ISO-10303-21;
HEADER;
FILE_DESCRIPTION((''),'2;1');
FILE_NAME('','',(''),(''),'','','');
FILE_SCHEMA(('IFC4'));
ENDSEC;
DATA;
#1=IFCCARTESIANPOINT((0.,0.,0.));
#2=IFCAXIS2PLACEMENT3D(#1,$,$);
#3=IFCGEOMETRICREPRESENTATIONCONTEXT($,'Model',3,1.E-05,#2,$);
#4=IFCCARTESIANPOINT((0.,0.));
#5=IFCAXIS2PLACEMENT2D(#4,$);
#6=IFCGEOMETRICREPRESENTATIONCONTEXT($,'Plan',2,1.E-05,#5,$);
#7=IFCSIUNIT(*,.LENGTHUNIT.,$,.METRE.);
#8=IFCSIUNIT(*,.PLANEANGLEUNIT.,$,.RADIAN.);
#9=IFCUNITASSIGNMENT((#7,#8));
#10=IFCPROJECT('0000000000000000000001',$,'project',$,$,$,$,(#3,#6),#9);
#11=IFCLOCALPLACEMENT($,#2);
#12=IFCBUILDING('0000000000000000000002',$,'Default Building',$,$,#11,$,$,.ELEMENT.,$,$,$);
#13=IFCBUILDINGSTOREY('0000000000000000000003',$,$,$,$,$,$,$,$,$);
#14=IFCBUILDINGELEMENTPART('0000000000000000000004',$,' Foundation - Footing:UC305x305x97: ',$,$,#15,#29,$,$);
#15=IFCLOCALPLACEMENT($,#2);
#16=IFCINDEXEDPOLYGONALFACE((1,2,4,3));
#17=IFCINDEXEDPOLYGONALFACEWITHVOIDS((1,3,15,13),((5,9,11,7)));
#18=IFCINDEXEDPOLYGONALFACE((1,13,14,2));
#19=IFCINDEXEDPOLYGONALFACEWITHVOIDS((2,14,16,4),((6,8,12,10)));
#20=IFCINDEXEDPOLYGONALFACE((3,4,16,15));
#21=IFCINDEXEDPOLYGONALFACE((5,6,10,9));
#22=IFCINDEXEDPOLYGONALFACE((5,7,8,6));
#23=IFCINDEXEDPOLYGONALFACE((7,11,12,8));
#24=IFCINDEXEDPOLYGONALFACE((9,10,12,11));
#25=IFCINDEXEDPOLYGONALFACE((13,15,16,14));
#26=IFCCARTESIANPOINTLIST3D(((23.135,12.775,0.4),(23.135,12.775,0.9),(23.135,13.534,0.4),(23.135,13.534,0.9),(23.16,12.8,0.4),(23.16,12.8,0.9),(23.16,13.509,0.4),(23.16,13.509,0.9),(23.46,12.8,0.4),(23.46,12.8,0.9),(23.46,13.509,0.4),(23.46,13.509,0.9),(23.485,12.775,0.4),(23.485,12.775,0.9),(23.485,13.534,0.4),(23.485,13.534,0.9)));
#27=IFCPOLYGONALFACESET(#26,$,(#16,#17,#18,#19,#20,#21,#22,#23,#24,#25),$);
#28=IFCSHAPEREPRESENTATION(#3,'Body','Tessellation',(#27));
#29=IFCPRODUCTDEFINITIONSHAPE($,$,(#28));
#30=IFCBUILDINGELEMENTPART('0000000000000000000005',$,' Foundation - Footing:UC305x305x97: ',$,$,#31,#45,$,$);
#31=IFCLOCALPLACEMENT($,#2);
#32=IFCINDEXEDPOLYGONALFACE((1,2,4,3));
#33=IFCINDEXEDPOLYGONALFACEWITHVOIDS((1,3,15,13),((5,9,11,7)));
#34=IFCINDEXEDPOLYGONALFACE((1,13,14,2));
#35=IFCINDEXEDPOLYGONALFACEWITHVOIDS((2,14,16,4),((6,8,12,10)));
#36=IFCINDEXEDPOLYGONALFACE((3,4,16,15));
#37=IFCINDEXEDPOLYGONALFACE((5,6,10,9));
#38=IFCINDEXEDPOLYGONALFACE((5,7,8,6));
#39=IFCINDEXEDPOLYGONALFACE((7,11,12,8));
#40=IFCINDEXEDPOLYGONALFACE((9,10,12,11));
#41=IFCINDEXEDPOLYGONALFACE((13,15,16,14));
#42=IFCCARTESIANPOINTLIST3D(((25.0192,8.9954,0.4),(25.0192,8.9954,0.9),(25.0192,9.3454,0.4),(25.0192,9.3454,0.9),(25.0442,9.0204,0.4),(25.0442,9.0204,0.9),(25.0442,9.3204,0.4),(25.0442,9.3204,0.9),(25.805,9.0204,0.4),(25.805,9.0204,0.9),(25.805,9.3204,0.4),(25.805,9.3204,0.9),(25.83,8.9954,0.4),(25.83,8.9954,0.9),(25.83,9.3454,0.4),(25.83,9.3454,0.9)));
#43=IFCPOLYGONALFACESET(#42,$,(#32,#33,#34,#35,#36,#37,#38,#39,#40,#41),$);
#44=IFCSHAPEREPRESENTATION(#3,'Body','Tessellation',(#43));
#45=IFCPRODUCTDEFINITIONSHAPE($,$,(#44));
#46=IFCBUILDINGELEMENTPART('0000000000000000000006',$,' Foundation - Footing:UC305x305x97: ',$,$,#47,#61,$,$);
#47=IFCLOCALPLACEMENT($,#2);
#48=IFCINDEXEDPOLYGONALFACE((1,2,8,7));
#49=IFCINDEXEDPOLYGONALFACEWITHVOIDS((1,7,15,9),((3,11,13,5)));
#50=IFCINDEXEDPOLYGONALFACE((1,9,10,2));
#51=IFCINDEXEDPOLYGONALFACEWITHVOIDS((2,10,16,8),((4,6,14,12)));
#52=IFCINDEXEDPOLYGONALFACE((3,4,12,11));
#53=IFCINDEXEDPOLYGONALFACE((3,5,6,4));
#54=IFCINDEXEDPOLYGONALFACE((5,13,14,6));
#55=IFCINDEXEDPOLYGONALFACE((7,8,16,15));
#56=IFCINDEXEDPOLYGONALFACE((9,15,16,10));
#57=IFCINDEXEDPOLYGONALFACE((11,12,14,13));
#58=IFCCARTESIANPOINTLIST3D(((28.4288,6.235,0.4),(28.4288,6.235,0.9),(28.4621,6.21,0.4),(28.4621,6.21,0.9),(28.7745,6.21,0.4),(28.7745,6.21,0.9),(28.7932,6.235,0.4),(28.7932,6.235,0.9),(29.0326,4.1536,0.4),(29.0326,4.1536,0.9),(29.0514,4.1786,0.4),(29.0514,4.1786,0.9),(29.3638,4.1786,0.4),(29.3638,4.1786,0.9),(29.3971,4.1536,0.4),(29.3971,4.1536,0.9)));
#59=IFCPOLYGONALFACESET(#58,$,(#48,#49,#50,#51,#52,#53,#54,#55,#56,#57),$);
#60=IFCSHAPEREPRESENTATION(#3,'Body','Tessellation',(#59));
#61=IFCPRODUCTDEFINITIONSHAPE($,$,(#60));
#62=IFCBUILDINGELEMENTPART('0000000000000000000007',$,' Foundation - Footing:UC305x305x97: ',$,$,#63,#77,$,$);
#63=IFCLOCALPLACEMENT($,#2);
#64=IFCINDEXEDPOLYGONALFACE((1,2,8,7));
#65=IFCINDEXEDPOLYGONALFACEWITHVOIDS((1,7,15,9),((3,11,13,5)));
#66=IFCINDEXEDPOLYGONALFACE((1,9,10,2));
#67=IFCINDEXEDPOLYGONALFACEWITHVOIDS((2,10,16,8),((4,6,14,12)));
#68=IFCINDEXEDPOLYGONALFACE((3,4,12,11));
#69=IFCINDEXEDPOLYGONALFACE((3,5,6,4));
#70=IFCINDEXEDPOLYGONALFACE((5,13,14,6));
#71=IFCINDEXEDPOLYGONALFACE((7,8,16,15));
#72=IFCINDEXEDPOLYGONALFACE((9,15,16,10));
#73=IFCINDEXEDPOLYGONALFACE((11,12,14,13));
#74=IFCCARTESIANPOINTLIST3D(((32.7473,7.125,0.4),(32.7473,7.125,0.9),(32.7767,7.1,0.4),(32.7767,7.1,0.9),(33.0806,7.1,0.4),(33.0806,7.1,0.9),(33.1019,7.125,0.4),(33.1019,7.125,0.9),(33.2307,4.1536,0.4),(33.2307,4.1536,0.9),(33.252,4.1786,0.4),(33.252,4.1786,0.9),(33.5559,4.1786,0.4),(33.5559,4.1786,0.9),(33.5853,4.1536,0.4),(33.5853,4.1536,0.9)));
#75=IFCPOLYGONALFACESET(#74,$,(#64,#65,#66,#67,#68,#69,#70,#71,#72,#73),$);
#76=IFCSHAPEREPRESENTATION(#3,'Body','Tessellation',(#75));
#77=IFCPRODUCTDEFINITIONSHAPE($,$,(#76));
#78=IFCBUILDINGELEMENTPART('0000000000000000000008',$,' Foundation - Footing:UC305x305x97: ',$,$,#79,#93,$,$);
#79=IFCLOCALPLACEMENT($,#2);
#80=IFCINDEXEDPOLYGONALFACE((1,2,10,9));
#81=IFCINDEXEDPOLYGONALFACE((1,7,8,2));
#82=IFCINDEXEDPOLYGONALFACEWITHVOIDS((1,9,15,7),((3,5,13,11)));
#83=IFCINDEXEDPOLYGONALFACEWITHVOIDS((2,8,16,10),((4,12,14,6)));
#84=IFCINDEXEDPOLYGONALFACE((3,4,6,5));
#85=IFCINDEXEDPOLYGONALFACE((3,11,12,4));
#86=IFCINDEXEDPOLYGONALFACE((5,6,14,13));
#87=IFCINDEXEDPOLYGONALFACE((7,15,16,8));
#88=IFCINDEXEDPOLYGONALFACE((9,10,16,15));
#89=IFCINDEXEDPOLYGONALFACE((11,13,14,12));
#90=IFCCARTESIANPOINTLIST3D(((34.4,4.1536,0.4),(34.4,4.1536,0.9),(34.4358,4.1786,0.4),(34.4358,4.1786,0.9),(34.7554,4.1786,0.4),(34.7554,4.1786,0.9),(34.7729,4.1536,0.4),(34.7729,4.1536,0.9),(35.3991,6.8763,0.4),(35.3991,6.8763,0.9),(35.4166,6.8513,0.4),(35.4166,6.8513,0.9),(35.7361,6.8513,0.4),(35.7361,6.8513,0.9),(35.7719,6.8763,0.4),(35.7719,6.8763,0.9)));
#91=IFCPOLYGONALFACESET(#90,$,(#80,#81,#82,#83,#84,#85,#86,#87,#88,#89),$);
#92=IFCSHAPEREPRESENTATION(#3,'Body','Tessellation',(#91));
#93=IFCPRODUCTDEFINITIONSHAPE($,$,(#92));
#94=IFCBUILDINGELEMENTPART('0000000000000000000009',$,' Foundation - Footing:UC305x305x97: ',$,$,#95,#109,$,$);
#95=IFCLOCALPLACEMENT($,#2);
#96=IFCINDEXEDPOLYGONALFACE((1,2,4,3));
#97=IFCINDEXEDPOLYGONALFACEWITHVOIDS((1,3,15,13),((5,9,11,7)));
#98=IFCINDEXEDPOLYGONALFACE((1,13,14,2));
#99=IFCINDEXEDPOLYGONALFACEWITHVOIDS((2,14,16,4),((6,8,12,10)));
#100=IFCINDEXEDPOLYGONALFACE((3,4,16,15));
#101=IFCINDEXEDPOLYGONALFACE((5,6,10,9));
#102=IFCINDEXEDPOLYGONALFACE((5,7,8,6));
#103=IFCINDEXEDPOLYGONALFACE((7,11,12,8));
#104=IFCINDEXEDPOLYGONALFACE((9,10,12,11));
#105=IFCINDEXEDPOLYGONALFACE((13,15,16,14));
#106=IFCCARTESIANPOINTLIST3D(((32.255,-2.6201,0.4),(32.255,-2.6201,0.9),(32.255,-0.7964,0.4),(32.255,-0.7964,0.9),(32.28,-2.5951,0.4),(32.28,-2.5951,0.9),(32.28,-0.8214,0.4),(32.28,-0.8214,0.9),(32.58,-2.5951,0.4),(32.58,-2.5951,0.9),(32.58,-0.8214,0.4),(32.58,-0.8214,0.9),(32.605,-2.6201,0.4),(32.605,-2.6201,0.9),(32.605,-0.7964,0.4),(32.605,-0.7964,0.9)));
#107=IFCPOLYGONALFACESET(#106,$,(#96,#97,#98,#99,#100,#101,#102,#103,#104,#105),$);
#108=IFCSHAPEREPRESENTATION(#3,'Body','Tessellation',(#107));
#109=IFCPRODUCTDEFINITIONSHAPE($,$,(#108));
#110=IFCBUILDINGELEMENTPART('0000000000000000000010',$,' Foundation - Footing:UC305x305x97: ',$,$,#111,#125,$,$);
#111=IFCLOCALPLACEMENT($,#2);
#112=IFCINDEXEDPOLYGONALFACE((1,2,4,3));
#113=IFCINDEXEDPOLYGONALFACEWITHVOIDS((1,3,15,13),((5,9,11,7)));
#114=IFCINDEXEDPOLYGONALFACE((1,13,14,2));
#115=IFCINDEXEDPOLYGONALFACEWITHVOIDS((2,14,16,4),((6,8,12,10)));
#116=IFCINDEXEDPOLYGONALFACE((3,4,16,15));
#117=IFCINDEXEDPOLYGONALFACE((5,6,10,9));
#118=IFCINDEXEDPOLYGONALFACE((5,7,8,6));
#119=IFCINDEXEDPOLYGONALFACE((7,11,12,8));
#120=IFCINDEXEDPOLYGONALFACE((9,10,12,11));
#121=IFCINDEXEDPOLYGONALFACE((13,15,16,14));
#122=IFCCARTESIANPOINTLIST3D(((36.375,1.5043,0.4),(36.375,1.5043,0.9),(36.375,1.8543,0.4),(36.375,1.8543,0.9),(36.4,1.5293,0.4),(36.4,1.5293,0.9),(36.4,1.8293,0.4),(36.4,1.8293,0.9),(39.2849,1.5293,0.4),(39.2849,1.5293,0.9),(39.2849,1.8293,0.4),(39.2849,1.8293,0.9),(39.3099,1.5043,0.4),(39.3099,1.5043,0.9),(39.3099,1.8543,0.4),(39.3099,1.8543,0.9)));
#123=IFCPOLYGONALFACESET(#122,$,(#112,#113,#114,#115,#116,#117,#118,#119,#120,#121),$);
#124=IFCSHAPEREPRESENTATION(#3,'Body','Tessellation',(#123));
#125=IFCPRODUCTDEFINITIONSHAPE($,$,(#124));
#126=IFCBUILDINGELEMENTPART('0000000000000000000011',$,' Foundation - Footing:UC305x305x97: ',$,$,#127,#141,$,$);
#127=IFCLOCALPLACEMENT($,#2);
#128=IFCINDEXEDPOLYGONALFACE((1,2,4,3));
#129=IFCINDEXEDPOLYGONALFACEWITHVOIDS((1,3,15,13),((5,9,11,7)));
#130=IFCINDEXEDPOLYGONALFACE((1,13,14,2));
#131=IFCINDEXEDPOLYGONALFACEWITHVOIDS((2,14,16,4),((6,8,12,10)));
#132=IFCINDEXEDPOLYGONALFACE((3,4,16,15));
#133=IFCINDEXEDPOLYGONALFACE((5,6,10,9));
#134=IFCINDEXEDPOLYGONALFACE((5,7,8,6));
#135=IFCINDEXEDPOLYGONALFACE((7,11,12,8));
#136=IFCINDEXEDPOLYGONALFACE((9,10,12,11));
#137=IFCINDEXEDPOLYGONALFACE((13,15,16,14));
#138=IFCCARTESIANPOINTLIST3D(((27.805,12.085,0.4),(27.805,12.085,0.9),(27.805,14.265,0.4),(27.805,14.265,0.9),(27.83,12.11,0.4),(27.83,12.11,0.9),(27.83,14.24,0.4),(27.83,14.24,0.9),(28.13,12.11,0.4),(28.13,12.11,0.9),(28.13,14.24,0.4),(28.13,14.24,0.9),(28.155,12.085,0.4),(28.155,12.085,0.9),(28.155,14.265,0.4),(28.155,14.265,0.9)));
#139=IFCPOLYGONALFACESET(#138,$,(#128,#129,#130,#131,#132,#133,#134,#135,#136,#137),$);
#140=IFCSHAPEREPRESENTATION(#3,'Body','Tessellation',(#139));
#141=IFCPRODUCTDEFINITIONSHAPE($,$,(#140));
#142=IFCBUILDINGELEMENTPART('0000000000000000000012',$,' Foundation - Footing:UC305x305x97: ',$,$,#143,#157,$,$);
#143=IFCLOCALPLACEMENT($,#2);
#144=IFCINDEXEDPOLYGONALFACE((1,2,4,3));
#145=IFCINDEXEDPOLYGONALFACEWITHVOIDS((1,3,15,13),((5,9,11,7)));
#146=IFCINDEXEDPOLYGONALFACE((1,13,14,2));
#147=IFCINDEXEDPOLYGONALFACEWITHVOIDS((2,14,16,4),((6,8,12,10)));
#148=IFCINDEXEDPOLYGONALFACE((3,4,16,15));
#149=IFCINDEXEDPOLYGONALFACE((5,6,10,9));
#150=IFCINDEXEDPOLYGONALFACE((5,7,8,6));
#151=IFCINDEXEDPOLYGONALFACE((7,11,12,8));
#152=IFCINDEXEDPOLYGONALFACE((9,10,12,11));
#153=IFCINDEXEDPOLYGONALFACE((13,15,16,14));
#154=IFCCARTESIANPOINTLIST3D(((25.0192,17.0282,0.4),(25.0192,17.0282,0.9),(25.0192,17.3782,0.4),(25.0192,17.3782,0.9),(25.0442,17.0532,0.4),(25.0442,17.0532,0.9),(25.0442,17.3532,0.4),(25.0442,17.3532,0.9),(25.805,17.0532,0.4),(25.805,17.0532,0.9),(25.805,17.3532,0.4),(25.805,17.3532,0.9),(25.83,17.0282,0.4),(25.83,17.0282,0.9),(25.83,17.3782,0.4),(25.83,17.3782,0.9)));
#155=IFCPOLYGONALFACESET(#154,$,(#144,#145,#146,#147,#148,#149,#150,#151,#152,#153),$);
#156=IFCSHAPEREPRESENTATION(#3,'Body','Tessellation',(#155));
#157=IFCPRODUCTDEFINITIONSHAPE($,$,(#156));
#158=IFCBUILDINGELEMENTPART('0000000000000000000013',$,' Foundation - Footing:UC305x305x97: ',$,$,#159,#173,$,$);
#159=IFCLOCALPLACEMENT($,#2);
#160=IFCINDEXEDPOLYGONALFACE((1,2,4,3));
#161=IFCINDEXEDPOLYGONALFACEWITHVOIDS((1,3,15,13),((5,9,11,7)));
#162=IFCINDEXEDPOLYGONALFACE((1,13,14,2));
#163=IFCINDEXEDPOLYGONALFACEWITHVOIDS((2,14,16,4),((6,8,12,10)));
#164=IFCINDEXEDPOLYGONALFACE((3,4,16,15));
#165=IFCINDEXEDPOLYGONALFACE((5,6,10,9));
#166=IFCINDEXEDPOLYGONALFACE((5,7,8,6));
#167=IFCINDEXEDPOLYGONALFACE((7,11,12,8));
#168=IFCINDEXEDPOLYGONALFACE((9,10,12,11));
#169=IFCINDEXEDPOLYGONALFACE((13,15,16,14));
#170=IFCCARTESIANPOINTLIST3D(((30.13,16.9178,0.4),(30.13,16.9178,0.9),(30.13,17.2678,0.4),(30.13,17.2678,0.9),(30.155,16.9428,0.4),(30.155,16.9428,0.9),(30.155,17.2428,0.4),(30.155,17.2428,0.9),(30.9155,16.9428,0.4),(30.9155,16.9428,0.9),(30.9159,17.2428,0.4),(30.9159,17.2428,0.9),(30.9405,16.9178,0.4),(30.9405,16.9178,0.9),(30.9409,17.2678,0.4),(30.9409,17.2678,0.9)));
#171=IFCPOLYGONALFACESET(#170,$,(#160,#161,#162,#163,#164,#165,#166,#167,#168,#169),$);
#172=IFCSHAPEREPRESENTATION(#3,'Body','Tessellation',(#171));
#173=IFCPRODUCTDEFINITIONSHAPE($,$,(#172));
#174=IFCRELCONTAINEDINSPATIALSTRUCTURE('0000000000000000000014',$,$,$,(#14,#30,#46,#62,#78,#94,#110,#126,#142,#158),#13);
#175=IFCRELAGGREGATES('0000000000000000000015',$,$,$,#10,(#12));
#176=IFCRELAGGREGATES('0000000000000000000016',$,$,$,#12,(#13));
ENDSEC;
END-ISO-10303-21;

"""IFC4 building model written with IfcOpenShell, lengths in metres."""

from ifc_helpers import new_model, si_unit, origin, origin_2d, place, context, project, spatial, polyline, outline, extrude, element, save


model = new_model("IFC4")

# Units and contexts
model_context = context("Model", 3, precision=1e-05, world=origin())
plan_context = context("Plan", 2, precision=1e-05, world=origin_2d())
ifc_project = project(units=[si_unit("LENGTHUNIT", "METRE"), si_unit("PLANEANGLEUNIT", "RADIAN")], contexts=[model_context, plan_context])

# Building, storey
building_placement = place(None, origin())
building = spatial("IfcBuilding", under=ifc_project, at=building_placement, Name="Default Building", CompositionType="ELEMENT")
storey = spatial("IfcBuildingStorey", under=building)

# Building element parts, openings
building_element_part_1 = element("IfcBuildingElementPart", 1, inside=storey, Name=" Foundation - Footing:UC305x305x97: ", context=model_context, shape_type="SweptSolid", body=[
    extrude(outline(polyline([(23.135, 12.775, 0.4), (23.485, 12.775, 0.4), (23.485, 13.534, 0.4), (23.135, 13.534, 0.4), (23.135, 12.775, 0.4)])), None, (0.0, 0.0, 1.0), 0.5),
])
element("IfcOpeningElement", 2, inside=storey, cuts=building_element_part_1, context=model_context, shape_type="SweptSolid", body=[
    extrude(outline(polyline([(23.16, 12.8, 0.4), (23.46, 12.8, 0.4), (23.46, 13.509, 0.4), (23.16, 13.509, 0.4), (23.16, 12.8, 0.4)])), None, (0.0, 0.0, 1.0), 0.5),
])
building_element_part_2 = element("IfcBuildingElementPart", 3, inside=storey, Name=" Foundation - Footing:UC305x305x97: ", context=model_context, shape_type="SweptSolid", body=[
    extrude(outline(polyline([(25.0192, 8.9954, 0.4), (25.83, 8.9954, 0.4), (25.83, 9.3454, 0.4), (25.0192, 9.3454, 0.4), (25.0192, 8.9954, 0.4)])), None, (0.0, 0.0, 1.0), 0.5),
])
element("IfcOpeningElement", 4, inside=storey, cuts=building_element_part_2, context=model_context, shape_type="SweptSolid", body=[
    extrude(outline(polyline([(25.0442, 9.0204, 0.4), (25.805, 9.0204, 0.4), (25.805, 9.3204, 0.4), (25.0442, 9.3204, 0.4), (25.0442, 9.0204, 0.4)])), None, (0.0, 0.0, 1.0), 0.5),
])
building_element_part_3 = element("IfcBuildingElementPart", 5, inside=storey, Name=" Foundation - Footing:UC305x305x97: ", context=model_context, shape_type="SweptSolid", body=[
    extrude(outline(polyline([(29.0326, 4.1536, 0.4), (29.3971, 4.1536, 0.4), (28.7932, 6.235, 0.4), (28.4288, 6.235, 0.4), (29.0326, 4.1536, 0.4)])), None, (0.0, 0.0, 1.0), 0.5),
])
element("IfcOpeningElement", 6, inside=storey, cuts=building_element_part_3, context=model_context, shape_type="SweptSolid", body=[
    extrude(outline(polyline([(29.0514, 4.1786, 0.4), (29.3638, 4.1786, 0.4), (28.7745, 6.21, 0.4), (28.4621, 6.21, 0.4), (29.0514, 4.1786, 0.4)])), None, (0.0, 0.0, 1.0), 0.5),
])
building_element_part_4 = element("IfcBuildingElementPart", 7, inside=storey, Name=" Foundation - Footing:UC305x305x97: ", context=model_context, shape_type="SweptSolid", body=[
    extrude(outline(polyline([(33.2307, 4.1536, 0.4), (33.5853, 4.1536, 0.4), (33.1019, 7.125, 0.4), (32.7473, 7.125, 0.4), (33.2307, 4.1536, 0.4)])), None, (0.0, 0.0, 1.0), 0.5),
])
element("IfcOpeningElement", 8, inside=storey, cuts=building_element_part_4, context=model_context, shape_type="SweptSolid", body=[
    extrude(outline(polyline([(33.252, 4.1786, 0.4), (33.5559, 4.1786, 0.4), (33.0806, 7.1, 0.4), (32.7767, 7.1, 0.4), (33.252, 4.1786, 0.4)])), None, (0.0, 0.0, 1.0), 0.5),
])
building_element_part_5 = element("IfcBuildingElementPart", 9, inside=storey, Name=" Foundation - Footing:UC305x305x97: ", context=model_context, shape_type="SweptSolid", body=[
    extrude(outline(polyline([(34.4, 4.1536, 0.4), (34.7729, 4.1536, 0.4), (35.7719, 6.8763, 0.4), (35.3991, 6.8763, 0.4), (34.4, 4.1536, 0.4)])), None, (0.0, 0.0, 1.0), 0.5),
])
element("IfcOpeningElement", 10, inside=storey, cuts=building_element_part_5, context=model_context, shape_type="SweptSolid", body=[
    extrude(outline(polyline([(34.4358, 4.1786, 0.4), (34.7554, 4.1786, 0.4), (35.7361, 6.8513, 0.4), (35.4166, 6.8513, 0.4), (34.4358, 4.1786, 0.4)])), None, (0.0, 0.0, 1.0), 0.5),
])
building_element_part_6 = element("IfcBuildingElementPart", 11, inside=storey, Name=" Foundation - Footing:UC305x305x97: ", context=model_context, shape_type="SweptSolid", body=[
    extrude(outline(polyline([(32.255, -2.6201, 0.4), (32.605, -2.6201, 0.4), (32.605, -0.7964, 0.4), (32.255, -0.7964, 0.4), (32.255, -2.6201, 0.4)])), None, (0.0, 0.0, 1.0), 0.5),
])
element("IfcOpeningElement", 12, inside=storey, cuts=building_element_part_6, context=model_context, shape_type="SweptSolid", body=[
    extrude(outline(polyline([(32.28, -2.5951, 0.4), (32.58, -2.5951, 0.4), (32.58, -0.8214, 0.4), (32.28, -0.8214, 0.4), (32.28, -2.5951, 0.4)])), None, (0.0, 0.0, 1.0), 0.5),
])
building_element_part_7 = element("IfcBuildingElementPart", 13, inside=storey, Name=" Foundation - Footing:UC305x305x97: ", context=model_context, shape_type="SweptSolid", body=[
    extrude(outline(polyline([(36.375, 1.5043, 0.4), (36.375, 1.8543, 0.4), (39.3099, 1.8543, 0.4), (39.3099, 1.5043, 0.4), (36.375, 1.5043, 0.4)])), None, (0.0, 0.0, 1.0), 0.5),
])
element("IfcOpeningElement", 14, inside=storey, cuts=building_element_part_7, context=model_context, shape_type="SweptSolid", body=[
    extrude(outline(polyline([(36.4, 1.5293, 0.4), (36.4, 1.8293, 0.4), (39.2849, 1.8293, 0.4), (39.2849, 1.5293, 0.4), (36.4, 1.5293, 0.4)])), None, (0.0, 0.0, 1.0), 0.5),
])
building_element_part_8 = element("IfcBuildingElementPart", 15, inside=storey, Name=" Foundation - Footing:UC305x305x97: ", context=model_context, shape_type="SweptSolid", body=[
    extrude(outline(polyline([(27.805, 12.085, 0.4), (28.155, 12.085, 0.4), (28.155, 14.265, 0.4), (27.805, 14.265, 0.4), (27.805, 12.085, 0.4)])), None, (0.0, 0.0, 1.0), 0.5),
])
element("IfcOpeningElement", 16, inside=storey, cuts=building_element_part_8, context=model_context, shape_type="SweptSolid", body=[
    extrude(outline(polyline([(27.83, 12.11, 0.4), (28.13, 12.11, 0.4), (28.13, 14.24, 0.4), (27.83, 14.24, 0.4), (27.83, 12.11, 0.4)])), None, (0.0, 0.0, 1.0), 0.5),
])
building_element_part_9 = element("IfcBuildingElementPart", 17, inside=storey, Name=" Foundation - Footing:UC305x305x97: ", context=model_context, shape_type="SweptSolid", body=[
    extrude(outline(polyline([(25.0192, 17.0282, 0.4), (25.0192, 17.3782, 0.4), (25.83, 17.3782, 0.4), (25.83, 17.0282, 0.4), (25.0192, 17.0282, 0.4)])), None, (0.0, 0.0, 1.0), 0.5),
])
element("IfcOpeningElement", 18, inside=storey, cuts=building_element_part_9, context=model_context, shape_type="SweptSolid", body=[
    extrude(outline(polyline([(25.0442, 17.0532, 0.4), (25.0442, 17.3532, 0.4), (25.805, 17.3532, 0.4), (25.805, 17.0532, 0.4), (25.0442, 17.0532, 0.4)])), None, (0.0, 0.0, 1.0), 0.5),
])
building_element_part_10 = element("IfcBuildingElementPart", 19, inside=storey, Name=" Foundation - Footing:UC305x305x97: ", context=model_context, shape_type="SweptSolid", body=[
    extrude(outline(polyline([(30.13, 16.9178, 0.4), (30.9405, 16.9178, 0.4), (30.9409, 17.2678, 0.4), (30.13, 17.2678, 0.4), (30.13, 16.9178, 0.4)])), None, (0.0, 0.0, 1.0), 0.5),
])
element("IfcOpeningElement", 20, inside=storey, cuts=building_element_part_10, context=model_context, shape_type="SweptSolid", body=[
    extrude(outline(polyline([(30.155, 16.9428, 0.4), (30.9155, 16.9428, 0.4), (30.9159, 17.2428, 0.4), (30.155, 17.2428, 0.4), (30.155, 16.9428, 0.4)])), None, (0.0, 0.0, 1.0), 0.5),
])

save(model, "model.ifc")
